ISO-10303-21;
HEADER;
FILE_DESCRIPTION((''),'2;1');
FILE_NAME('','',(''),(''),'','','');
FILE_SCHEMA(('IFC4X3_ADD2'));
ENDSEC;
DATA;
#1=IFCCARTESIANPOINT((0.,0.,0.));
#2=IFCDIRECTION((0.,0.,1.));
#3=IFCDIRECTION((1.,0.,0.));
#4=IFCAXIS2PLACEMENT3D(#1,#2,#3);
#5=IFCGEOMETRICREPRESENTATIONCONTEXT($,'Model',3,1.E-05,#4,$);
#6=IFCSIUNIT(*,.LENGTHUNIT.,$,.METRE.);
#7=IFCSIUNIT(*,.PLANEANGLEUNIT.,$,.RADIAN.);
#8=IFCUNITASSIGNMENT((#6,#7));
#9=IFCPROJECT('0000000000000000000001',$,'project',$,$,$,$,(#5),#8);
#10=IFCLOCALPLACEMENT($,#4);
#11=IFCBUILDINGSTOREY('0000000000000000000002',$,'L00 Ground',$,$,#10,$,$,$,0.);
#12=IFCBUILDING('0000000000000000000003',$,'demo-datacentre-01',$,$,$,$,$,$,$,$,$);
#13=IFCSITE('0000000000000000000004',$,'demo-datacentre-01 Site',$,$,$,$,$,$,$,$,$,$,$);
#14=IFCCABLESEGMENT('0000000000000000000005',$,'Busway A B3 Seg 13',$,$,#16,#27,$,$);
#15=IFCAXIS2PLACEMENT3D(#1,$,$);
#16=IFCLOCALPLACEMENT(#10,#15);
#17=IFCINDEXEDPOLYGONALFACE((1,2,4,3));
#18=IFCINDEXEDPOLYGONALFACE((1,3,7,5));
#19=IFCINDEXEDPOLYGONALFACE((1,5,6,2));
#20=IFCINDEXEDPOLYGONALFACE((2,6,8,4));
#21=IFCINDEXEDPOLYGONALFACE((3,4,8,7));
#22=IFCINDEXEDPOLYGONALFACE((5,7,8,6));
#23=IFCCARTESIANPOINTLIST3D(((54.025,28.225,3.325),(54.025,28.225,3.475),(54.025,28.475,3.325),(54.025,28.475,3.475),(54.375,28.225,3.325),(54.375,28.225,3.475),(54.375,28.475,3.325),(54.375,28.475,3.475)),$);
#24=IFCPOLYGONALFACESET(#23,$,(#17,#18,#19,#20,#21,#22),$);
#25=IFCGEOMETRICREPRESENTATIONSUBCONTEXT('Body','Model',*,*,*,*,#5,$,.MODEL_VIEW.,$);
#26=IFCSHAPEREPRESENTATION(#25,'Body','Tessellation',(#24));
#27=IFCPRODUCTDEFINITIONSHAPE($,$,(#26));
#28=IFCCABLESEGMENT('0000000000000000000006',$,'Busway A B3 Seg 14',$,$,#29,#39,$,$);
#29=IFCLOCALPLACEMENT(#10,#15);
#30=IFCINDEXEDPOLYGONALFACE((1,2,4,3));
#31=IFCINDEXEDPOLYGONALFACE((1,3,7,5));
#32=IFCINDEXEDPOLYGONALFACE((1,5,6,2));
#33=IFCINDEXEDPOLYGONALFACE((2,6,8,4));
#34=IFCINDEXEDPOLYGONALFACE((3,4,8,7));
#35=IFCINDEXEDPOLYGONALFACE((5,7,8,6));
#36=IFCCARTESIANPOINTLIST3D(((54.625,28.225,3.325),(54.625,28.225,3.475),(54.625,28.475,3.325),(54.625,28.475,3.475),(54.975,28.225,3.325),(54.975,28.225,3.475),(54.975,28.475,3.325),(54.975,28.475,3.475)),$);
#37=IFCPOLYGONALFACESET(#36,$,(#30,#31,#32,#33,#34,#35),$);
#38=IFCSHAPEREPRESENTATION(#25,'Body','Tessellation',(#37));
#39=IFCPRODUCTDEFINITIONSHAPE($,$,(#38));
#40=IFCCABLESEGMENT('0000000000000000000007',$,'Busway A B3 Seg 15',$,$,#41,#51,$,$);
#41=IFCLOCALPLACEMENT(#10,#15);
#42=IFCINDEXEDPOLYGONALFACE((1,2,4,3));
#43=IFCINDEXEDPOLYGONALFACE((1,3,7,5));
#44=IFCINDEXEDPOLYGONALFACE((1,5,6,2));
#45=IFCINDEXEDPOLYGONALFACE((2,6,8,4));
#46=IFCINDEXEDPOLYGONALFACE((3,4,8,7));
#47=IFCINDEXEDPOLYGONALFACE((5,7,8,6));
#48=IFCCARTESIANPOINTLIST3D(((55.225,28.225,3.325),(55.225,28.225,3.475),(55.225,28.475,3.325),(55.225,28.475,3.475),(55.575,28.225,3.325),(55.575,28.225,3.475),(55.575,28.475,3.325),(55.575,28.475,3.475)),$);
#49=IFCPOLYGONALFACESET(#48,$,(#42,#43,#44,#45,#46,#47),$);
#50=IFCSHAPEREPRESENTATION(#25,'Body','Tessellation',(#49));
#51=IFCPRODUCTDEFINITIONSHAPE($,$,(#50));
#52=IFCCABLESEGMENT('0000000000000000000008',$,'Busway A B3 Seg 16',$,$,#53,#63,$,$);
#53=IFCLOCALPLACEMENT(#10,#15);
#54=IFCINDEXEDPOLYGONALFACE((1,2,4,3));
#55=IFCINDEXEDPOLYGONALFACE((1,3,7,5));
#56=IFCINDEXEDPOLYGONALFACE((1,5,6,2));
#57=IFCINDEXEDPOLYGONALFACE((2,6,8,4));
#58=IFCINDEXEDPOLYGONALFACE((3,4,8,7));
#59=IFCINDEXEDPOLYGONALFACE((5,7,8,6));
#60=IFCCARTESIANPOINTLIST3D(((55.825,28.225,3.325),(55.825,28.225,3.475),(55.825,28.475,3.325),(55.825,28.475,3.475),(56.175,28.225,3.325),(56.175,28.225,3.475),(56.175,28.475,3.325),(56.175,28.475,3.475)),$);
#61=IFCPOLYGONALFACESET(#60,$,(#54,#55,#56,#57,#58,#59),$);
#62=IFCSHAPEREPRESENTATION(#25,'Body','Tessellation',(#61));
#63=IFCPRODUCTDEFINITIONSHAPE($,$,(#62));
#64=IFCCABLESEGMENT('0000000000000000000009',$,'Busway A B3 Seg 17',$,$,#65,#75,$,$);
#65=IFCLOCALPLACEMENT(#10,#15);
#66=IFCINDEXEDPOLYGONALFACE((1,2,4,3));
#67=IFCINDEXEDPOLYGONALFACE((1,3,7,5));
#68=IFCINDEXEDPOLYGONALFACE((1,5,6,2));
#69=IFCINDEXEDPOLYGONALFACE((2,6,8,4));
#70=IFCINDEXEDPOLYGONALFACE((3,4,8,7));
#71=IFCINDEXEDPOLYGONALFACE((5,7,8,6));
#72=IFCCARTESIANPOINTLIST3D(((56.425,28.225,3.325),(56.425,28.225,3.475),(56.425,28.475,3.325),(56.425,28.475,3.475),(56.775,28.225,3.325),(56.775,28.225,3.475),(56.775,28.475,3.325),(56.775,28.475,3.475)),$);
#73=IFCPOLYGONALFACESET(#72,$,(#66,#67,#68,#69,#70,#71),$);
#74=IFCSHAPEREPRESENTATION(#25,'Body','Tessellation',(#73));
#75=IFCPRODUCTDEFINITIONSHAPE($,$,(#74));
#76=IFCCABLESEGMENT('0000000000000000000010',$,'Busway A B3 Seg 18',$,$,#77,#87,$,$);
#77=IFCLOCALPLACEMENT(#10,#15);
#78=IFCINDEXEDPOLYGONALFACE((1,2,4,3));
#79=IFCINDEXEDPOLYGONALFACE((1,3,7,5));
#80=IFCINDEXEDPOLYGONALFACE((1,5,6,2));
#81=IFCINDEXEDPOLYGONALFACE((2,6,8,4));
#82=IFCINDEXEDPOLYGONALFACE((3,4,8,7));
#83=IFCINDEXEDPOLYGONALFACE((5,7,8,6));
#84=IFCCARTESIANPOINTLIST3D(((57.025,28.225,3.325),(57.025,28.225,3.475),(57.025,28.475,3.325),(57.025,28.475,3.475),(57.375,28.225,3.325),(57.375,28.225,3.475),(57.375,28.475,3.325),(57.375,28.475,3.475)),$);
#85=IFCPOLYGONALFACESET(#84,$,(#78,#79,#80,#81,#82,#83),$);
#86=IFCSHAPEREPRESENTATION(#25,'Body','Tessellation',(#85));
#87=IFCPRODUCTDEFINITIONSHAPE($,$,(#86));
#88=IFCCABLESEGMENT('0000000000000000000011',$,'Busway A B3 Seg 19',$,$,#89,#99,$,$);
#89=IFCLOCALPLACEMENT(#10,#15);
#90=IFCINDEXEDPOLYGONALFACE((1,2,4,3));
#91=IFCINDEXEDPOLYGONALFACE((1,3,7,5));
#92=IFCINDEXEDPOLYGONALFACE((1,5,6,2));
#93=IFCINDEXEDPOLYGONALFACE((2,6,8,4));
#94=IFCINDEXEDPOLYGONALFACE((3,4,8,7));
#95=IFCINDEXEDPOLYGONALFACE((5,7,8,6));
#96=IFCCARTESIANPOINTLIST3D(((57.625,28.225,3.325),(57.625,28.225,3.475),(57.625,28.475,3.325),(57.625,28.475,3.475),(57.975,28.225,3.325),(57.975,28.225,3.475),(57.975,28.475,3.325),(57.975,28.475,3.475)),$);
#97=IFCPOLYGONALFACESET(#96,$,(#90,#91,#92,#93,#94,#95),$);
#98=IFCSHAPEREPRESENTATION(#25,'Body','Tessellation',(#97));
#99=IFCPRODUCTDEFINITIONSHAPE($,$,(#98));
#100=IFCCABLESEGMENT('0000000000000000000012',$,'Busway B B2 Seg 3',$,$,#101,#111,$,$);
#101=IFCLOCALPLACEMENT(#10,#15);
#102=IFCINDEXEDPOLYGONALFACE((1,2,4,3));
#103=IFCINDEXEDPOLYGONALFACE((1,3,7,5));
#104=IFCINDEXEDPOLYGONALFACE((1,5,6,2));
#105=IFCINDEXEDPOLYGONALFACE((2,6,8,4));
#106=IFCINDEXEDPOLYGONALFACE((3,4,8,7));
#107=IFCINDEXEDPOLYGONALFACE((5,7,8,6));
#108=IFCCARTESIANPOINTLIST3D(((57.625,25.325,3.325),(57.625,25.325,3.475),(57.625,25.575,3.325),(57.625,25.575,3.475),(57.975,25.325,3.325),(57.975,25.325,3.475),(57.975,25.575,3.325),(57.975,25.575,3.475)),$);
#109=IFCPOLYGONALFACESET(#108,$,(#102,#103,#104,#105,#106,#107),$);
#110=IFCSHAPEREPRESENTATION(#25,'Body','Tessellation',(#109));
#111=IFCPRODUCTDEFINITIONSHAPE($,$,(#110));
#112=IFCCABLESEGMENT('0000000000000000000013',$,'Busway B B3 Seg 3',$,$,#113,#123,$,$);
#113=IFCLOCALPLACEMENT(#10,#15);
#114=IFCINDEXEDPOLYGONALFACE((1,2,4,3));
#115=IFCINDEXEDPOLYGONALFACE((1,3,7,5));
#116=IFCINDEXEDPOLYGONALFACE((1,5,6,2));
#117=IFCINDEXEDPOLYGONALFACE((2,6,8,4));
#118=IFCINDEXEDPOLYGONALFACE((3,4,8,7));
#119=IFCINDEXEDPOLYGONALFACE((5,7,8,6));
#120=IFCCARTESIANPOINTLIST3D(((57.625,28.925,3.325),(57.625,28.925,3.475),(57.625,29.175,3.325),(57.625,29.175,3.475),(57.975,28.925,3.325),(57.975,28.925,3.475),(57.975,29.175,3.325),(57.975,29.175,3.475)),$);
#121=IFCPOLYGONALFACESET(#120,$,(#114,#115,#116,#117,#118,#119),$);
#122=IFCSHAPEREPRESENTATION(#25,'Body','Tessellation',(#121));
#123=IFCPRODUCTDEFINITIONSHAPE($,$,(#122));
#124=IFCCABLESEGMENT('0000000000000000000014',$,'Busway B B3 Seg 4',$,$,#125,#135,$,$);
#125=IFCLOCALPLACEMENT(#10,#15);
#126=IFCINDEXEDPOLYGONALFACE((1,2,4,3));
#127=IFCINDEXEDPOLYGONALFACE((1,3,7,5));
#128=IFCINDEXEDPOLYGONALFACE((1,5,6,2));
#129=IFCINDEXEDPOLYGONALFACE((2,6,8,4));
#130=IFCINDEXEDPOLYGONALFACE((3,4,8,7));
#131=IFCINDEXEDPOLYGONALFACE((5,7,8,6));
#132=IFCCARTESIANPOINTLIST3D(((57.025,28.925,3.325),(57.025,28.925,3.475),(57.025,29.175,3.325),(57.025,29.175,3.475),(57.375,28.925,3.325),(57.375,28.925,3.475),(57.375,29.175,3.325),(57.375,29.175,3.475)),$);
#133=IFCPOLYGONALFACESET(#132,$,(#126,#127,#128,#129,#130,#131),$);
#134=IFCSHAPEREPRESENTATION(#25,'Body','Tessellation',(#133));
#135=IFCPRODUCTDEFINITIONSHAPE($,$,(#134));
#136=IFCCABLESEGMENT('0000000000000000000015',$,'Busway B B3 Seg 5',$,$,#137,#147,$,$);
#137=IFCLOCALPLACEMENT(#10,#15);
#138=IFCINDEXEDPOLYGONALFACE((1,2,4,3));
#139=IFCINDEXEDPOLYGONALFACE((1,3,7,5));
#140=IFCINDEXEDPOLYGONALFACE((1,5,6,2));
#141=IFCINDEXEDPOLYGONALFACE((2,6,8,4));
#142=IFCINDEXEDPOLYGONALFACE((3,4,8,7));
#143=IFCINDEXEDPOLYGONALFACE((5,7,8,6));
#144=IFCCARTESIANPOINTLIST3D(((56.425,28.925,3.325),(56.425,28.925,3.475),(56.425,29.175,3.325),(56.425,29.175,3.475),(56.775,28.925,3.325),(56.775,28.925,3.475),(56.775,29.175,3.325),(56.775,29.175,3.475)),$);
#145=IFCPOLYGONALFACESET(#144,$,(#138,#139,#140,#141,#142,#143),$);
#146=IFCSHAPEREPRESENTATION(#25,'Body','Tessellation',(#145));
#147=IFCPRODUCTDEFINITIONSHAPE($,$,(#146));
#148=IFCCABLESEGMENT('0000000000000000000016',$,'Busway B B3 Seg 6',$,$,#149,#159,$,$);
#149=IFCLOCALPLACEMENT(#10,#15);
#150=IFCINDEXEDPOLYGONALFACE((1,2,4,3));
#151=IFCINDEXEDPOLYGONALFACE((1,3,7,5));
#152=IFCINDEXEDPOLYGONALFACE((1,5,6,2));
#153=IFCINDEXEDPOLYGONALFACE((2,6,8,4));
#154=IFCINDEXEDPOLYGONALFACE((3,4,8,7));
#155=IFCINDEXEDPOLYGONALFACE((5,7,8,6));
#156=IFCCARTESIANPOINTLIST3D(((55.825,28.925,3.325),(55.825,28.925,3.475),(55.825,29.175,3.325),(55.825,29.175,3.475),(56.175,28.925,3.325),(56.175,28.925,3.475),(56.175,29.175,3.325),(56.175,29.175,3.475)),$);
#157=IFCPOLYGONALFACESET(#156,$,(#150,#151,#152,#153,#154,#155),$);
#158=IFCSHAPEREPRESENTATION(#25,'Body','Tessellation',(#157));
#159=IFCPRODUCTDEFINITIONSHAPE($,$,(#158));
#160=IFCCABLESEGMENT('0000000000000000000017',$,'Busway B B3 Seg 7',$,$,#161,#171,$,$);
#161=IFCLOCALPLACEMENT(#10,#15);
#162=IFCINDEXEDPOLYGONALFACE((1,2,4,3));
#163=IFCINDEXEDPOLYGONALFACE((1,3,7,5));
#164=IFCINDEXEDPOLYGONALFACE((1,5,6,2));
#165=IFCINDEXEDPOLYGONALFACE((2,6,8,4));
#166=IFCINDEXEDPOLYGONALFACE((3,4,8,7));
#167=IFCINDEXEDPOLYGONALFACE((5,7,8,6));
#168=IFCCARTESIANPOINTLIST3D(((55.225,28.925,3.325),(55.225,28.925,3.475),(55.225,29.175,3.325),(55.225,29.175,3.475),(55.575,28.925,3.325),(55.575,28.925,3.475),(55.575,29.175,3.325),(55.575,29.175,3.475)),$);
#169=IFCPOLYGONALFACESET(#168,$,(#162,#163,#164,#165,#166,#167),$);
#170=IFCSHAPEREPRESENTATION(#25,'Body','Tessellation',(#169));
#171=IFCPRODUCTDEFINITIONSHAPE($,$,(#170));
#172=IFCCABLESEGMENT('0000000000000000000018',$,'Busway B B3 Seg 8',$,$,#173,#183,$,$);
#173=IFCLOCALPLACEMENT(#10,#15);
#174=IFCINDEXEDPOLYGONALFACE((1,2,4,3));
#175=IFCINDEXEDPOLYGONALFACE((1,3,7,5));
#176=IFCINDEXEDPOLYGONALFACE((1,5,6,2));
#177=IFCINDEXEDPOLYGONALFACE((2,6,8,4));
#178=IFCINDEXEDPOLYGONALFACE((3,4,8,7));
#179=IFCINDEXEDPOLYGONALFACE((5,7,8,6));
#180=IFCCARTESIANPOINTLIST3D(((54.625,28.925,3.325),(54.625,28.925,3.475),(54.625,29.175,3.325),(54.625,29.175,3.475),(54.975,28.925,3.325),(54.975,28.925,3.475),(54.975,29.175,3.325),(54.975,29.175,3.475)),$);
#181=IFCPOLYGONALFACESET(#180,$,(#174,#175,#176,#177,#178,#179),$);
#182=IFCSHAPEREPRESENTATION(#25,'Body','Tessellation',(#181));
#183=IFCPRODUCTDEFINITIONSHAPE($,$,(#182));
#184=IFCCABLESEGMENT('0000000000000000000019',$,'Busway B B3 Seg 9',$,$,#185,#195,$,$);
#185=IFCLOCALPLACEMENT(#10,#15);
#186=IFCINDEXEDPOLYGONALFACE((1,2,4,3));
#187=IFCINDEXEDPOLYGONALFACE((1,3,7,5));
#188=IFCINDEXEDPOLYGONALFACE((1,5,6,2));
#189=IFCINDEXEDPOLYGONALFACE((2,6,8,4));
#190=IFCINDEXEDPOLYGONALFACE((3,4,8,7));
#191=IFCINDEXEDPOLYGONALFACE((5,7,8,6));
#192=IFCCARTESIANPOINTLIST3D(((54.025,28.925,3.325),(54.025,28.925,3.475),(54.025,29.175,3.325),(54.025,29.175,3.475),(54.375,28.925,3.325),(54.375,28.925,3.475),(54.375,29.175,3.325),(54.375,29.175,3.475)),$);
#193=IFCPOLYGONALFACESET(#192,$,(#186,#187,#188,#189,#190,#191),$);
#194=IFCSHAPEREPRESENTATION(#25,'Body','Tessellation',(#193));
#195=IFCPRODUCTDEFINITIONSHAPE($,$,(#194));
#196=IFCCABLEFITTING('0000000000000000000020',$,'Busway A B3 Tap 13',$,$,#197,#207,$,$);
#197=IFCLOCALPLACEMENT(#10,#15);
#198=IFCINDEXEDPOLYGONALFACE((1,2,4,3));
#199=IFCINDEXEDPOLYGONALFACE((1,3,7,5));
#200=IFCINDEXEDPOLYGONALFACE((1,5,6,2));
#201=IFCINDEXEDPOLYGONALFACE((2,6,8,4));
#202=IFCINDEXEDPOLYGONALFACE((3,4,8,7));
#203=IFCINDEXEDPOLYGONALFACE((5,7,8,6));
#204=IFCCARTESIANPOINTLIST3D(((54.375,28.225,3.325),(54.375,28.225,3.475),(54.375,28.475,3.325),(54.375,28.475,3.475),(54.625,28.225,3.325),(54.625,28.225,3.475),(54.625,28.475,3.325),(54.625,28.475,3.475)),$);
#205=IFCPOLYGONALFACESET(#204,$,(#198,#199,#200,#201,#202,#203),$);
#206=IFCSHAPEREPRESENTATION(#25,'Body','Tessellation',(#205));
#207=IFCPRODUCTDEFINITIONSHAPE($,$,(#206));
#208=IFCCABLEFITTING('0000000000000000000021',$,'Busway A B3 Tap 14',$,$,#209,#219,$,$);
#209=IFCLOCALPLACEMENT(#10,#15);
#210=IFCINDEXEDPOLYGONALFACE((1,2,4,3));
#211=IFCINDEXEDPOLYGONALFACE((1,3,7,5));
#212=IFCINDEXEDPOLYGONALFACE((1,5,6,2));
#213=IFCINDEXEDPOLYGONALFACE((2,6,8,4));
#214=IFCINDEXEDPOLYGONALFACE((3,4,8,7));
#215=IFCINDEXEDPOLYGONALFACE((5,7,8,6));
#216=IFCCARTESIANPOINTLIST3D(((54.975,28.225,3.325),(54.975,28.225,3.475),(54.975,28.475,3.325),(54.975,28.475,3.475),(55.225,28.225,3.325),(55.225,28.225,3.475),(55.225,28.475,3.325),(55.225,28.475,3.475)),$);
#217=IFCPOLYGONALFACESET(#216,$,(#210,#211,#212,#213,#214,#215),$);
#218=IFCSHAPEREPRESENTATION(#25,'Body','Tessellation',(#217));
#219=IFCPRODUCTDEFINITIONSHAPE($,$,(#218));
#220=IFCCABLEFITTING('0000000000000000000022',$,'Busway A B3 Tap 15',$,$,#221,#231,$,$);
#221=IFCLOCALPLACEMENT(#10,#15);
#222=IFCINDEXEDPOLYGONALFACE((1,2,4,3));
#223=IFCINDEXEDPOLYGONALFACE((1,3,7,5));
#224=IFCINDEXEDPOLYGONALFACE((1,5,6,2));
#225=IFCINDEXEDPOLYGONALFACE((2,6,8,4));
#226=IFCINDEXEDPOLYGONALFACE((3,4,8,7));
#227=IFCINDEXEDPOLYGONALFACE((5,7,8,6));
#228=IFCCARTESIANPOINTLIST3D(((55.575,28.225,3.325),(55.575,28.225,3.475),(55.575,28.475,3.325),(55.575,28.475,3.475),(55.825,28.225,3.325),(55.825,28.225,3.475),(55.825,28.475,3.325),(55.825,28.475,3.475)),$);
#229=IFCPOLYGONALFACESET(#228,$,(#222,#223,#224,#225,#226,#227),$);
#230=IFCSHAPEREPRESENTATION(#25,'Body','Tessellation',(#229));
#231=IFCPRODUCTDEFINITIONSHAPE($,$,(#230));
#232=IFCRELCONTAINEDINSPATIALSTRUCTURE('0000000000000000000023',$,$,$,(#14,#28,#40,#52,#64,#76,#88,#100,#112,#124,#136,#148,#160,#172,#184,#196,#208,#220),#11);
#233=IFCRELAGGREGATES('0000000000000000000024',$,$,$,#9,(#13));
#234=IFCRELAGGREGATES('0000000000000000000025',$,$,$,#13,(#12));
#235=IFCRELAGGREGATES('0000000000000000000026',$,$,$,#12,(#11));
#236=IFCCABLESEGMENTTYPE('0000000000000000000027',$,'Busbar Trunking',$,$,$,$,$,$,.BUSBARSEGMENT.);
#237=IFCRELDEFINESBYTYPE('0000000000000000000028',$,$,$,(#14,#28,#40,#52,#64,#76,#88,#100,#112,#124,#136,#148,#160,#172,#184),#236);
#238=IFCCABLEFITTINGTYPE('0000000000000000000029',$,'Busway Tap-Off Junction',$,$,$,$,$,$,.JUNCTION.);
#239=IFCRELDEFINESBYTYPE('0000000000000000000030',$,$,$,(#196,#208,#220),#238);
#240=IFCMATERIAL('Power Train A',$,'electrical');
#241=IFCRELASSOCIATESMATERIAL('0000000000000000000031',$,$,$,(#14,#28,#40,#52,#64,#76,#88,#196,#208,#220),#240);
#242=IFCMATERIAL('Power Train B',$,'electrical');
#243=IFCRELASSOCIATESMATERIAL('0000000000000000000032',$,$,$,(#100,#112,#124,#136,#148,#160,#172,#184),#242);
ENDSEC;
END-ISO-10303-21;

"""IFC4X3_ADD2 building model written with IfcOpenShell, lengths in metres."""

from ifc_helpers import new_model, si_unit, frame, origin_with_axes, place, context, subcontext, project, spatial, rectangle, extrude, material, type_object, element, save


model = new_model("IFC4X3_ADD2")

# Units and contexts
model_context = context("Model", 3, precision=1e-05, world=origin_with_axes())
body_context = subcontext(model_context, "Body", "Model", "MODEL_VIEW")
ifc_project = project(units=[si_unit("LENGTHUNIT", "METRE"), si_unit("PLANEANGLEUNIT", "RADIAN")], contexts=[model_context])

# Site, building, storey
site = spatial("IfcSite", under=ifc_project, Name="demo-datacentre-01 Site")
building = spatial("IfcBuilding", under=site, Name="demo-datacentre-01")
storey_placement = place(None, origin_with_axes())
storey = spatial("IfcBuildingStorey", under=building, at=storey_placement, Name="L00 Ground", Elevation=0.0)

# Cable segments
ifc_material_1 = material(Name="Power Train A", Category="electrical")
cable_segment_type_1 = type_object("IfcCableSegmentType", Name="Busbar Trunking", PredefinedType="BUSBARSEGMENT")
cable_segment_1_placement = place(storey_placement, frame((54.025, 28.35, 3.4), z_axis=(1.0, 0.0, 0.0), x_axis=(0.0, 1.0, 0.0)))
element("IfcCableSegment", 1, at=cable_segment_1_placement, inside=storey, type_object=cable_segment_type_1, material=ifc_material_1, Name="Busway A B3 Seg 13", context=body_context, shape_type="SweptSolid", body=[
    extrude(rectangle(XDim=0.25, YDim=0.15), origin_with_axes(), (0.0, 0.0, 1.0), 0.35),
])
cable_segment_2_placement = place(storey_placement, frame((54.625, 28.35, 3.4), z_axis=(1.0, 0.0, 0.0), x_axis=(0.0, 1.0, 0.0)))
element("IfcCableSegment", 2, at=cable_segment_2_placement, inside=storey, type_object=cable_segment_type_1, material=ifc_material_1, Name="Busway A B3 Seg 14", context=body_context, shape_type="SweptSolid", body=[
    extrude(rectangle(XDim=0.25, YDim=0.15), origin_with_axes(), (0.0, 0.0, 1.0), 0.35),
])
for number, where, z_axis, x_axis, name in (
    (3, (55.225, 28.35, 3.4), (1.0, 0.0, 0.0), (0.0, 1.0, 0.0), "Busway A B3 Seg 15"),
    (4, (55.825, 28.35, 3.4), (1.0, 0.0, 0.0), (0.0, 1.0, 0.0), "Busway A B3 Seg 16"),
    (5, (56.425, 28.35, 3.4), (1.0, 0.0, 0.0), (0.0, 1.0, 0.0), "Busway A B3 Seg 17"),
    (6, (57.025, 28.35, 3.4), (1.0, 0.0, 0.0), (0.0, 1.0, 0.0), "Busway A B3 Seg 18"),
):
    element("IfcCableSegment", number, at=place(storey_placement, frame(where, z_axis=z_axis, x_axis=x_axis)), inside=storey, type_object=cable_segment_type_1, material=ifc_material_1, Name=name, context=body_context, shape_type="SweptSolid", body=[
        extrude(rectangle(XDim=0.25, YDim=0.15), origin_with_axes(), (0.0, 0.0, 1.0), 0.35),
    ])
cable_segment_3_placement = place(storey_placement, frame((57.625, 28.35, 3.4), z_axis=(1.0, 0.0, 0.0), x_axis=(0.0, 1.0, 0.0)))
element("IfcCableSegment", 7, at=cable_segment_3_placement, inside=storey, type_object=cable_segment_type_1, material=ifc_material_1, Name="Busway A B3 Seg 19", context=body_context, shape_type="SweptSolid", body=[
    extrude(rectangle(XDim=0.25, YDim=0.15), origin_with_axes(), (0.0, 0.0, 1.0), 0.35),
])
ifc_material_2 = material(Name="Power Train B", Category="electrical")
for number, where, z_axis, x_axis, name in (
    (8, (57.975, 25.45, 3.4), (-1.0, 0.0, 0.0), (0.0, -1.0, 0.0), "Busway B B2 Seg 3"),
    (9, (57.975, 29.05, 3.4), (-1.0, 0.0, 0.0), (0.0, -1.0, 0.0), "Busway B B3 Seg 3"),
):
    element("IfcCableSegment", number, at=place(storey_placement, frame(where, z_axis=z_axis, x_axis=x_axis)), inside=storey, type_object=cable_segment_type_1, material=ifc_material_2, Name=name, context=body_context, shape_type="SweptSolid", body=[
        extrude(rectangle(XDim=0.25, YDim=0.15), origin_with_axes(), (0.0, 0.0, 1.0), 0.35),
    ])
for number, where, z_axis, x_axis, name in (
    (10, (57.375, 29.05, 3.4), (-1.0, 0.0, 0.0), (0.0, -1.0, 0.0), "Busway B B3 Seg 4"),
    (11, (56.775, 29.05, 3.4), (-1.0, 0.0, 0.0), (0.0, -1.0, 0.0), "Busway B B3 Seg 5"),
    (12, (56.175, 29.05, 3.4), (-1.0, 0.0, 0.0), (0.0, -1.0, 0.0), "Busway B B3 Seg 6"),
    (13, (55.575, 29.05, 3.4), (-1.0, 0.0, 0.0), (0.0, -1.0, 0.0), "Busway B B3 Seg 7"),
):
    element("IfcCableSegment", number, at=place(storey_placement, frame(where, z_axis=z_axis, x_axis=x_axis)), inside=storey, type_object=cable_segment_type_1, material=ifc_material_2, Name=name, context=body_context, shape_type="SweptSolid", body=[
        extrude(rectangle(XDim=0.25, YDim=0.15), origin_with_axes(), (0.0, 0.0, 1.0), 0.35),
    ])
cable_segment_4_placement = place(storey_placement, frame((54.975, 29.05, 3.4), z_axis=(-1.0, 0.0, 0.0), x_axis=(0.0, -1.0, 0.0)))
element("IfcCableSegment", 14, at=cable_segment_4_placement, inside=storey, type_object=cable_segment_type_1, material=ifc_material_2, Name="Busway B B3 Seg 8", context=body_context, shape_type="SweptSolid", body=[
    extrude(rectangle(XDim=0.25, YDim=0.15), origin_with_axes(), (0.0, 0.0, 1.0), 0.35),
])
cable_segment_5_placement = place(storey_placement, frame((54.375, 29.05, 3.4), z_axis=(-1.0, 0.0, 0.0), x_axis=(0.0, -1.0, 0.0)))
element("IfcCableSegment", 15, at=cable_segment_5_placement, inside=storey, type_object=cable_segment_type_1, material=ifc_material_2, Name="Busway B B3 Seg 9", context=body_context, shape_type="SweptSolid", body=[
    extrude(rectangle(XDim=0.25, YDim=0.15), origin_with_axes(), (0.0, 0.0, 1.0), 0.35),
])

# Cable fittings
cable_fitting_type = type_object("IfcCableFittingType", Name="Busway Tap-Off Junction", PredefinedType="JUNCTION")
for number, where, z_axis, x_axis, name in (
    (16, (54.5, 28.35, 3.325), (0.0, 0.0, 1.0), (1.0, 0.0, 0.0), "Busway A B3 Tap 13"),
    (17, (55.1, 28.35, 3.325), (0.0, 0.0, 1.0), (1.0, 0.0, 0.0), "Busway A B3 Tap 14"),
    (18, (55.7, 28.35, 3.325), (0.0, 0.0, 1.0), (1.0, 0.0, 0.0), "Busway A B3 Tap 15"),
):
    element("IfcCableFitting", number, at=place(storey_placement, frame(where, z_axis=z_axis, x_axis=x_axis)), inside=storey, type_object=cable_fitting_type, material=ifc_material_1, Name=name, context=body_context, shape_type="SweptSolid", body=[
        extrude(rectangle(XDim=0.25, YDim=0.25), origin_with_axes(), (0.0, 0.0, 1.0), 0.15),
    ])

save(model, "model.ifc")
